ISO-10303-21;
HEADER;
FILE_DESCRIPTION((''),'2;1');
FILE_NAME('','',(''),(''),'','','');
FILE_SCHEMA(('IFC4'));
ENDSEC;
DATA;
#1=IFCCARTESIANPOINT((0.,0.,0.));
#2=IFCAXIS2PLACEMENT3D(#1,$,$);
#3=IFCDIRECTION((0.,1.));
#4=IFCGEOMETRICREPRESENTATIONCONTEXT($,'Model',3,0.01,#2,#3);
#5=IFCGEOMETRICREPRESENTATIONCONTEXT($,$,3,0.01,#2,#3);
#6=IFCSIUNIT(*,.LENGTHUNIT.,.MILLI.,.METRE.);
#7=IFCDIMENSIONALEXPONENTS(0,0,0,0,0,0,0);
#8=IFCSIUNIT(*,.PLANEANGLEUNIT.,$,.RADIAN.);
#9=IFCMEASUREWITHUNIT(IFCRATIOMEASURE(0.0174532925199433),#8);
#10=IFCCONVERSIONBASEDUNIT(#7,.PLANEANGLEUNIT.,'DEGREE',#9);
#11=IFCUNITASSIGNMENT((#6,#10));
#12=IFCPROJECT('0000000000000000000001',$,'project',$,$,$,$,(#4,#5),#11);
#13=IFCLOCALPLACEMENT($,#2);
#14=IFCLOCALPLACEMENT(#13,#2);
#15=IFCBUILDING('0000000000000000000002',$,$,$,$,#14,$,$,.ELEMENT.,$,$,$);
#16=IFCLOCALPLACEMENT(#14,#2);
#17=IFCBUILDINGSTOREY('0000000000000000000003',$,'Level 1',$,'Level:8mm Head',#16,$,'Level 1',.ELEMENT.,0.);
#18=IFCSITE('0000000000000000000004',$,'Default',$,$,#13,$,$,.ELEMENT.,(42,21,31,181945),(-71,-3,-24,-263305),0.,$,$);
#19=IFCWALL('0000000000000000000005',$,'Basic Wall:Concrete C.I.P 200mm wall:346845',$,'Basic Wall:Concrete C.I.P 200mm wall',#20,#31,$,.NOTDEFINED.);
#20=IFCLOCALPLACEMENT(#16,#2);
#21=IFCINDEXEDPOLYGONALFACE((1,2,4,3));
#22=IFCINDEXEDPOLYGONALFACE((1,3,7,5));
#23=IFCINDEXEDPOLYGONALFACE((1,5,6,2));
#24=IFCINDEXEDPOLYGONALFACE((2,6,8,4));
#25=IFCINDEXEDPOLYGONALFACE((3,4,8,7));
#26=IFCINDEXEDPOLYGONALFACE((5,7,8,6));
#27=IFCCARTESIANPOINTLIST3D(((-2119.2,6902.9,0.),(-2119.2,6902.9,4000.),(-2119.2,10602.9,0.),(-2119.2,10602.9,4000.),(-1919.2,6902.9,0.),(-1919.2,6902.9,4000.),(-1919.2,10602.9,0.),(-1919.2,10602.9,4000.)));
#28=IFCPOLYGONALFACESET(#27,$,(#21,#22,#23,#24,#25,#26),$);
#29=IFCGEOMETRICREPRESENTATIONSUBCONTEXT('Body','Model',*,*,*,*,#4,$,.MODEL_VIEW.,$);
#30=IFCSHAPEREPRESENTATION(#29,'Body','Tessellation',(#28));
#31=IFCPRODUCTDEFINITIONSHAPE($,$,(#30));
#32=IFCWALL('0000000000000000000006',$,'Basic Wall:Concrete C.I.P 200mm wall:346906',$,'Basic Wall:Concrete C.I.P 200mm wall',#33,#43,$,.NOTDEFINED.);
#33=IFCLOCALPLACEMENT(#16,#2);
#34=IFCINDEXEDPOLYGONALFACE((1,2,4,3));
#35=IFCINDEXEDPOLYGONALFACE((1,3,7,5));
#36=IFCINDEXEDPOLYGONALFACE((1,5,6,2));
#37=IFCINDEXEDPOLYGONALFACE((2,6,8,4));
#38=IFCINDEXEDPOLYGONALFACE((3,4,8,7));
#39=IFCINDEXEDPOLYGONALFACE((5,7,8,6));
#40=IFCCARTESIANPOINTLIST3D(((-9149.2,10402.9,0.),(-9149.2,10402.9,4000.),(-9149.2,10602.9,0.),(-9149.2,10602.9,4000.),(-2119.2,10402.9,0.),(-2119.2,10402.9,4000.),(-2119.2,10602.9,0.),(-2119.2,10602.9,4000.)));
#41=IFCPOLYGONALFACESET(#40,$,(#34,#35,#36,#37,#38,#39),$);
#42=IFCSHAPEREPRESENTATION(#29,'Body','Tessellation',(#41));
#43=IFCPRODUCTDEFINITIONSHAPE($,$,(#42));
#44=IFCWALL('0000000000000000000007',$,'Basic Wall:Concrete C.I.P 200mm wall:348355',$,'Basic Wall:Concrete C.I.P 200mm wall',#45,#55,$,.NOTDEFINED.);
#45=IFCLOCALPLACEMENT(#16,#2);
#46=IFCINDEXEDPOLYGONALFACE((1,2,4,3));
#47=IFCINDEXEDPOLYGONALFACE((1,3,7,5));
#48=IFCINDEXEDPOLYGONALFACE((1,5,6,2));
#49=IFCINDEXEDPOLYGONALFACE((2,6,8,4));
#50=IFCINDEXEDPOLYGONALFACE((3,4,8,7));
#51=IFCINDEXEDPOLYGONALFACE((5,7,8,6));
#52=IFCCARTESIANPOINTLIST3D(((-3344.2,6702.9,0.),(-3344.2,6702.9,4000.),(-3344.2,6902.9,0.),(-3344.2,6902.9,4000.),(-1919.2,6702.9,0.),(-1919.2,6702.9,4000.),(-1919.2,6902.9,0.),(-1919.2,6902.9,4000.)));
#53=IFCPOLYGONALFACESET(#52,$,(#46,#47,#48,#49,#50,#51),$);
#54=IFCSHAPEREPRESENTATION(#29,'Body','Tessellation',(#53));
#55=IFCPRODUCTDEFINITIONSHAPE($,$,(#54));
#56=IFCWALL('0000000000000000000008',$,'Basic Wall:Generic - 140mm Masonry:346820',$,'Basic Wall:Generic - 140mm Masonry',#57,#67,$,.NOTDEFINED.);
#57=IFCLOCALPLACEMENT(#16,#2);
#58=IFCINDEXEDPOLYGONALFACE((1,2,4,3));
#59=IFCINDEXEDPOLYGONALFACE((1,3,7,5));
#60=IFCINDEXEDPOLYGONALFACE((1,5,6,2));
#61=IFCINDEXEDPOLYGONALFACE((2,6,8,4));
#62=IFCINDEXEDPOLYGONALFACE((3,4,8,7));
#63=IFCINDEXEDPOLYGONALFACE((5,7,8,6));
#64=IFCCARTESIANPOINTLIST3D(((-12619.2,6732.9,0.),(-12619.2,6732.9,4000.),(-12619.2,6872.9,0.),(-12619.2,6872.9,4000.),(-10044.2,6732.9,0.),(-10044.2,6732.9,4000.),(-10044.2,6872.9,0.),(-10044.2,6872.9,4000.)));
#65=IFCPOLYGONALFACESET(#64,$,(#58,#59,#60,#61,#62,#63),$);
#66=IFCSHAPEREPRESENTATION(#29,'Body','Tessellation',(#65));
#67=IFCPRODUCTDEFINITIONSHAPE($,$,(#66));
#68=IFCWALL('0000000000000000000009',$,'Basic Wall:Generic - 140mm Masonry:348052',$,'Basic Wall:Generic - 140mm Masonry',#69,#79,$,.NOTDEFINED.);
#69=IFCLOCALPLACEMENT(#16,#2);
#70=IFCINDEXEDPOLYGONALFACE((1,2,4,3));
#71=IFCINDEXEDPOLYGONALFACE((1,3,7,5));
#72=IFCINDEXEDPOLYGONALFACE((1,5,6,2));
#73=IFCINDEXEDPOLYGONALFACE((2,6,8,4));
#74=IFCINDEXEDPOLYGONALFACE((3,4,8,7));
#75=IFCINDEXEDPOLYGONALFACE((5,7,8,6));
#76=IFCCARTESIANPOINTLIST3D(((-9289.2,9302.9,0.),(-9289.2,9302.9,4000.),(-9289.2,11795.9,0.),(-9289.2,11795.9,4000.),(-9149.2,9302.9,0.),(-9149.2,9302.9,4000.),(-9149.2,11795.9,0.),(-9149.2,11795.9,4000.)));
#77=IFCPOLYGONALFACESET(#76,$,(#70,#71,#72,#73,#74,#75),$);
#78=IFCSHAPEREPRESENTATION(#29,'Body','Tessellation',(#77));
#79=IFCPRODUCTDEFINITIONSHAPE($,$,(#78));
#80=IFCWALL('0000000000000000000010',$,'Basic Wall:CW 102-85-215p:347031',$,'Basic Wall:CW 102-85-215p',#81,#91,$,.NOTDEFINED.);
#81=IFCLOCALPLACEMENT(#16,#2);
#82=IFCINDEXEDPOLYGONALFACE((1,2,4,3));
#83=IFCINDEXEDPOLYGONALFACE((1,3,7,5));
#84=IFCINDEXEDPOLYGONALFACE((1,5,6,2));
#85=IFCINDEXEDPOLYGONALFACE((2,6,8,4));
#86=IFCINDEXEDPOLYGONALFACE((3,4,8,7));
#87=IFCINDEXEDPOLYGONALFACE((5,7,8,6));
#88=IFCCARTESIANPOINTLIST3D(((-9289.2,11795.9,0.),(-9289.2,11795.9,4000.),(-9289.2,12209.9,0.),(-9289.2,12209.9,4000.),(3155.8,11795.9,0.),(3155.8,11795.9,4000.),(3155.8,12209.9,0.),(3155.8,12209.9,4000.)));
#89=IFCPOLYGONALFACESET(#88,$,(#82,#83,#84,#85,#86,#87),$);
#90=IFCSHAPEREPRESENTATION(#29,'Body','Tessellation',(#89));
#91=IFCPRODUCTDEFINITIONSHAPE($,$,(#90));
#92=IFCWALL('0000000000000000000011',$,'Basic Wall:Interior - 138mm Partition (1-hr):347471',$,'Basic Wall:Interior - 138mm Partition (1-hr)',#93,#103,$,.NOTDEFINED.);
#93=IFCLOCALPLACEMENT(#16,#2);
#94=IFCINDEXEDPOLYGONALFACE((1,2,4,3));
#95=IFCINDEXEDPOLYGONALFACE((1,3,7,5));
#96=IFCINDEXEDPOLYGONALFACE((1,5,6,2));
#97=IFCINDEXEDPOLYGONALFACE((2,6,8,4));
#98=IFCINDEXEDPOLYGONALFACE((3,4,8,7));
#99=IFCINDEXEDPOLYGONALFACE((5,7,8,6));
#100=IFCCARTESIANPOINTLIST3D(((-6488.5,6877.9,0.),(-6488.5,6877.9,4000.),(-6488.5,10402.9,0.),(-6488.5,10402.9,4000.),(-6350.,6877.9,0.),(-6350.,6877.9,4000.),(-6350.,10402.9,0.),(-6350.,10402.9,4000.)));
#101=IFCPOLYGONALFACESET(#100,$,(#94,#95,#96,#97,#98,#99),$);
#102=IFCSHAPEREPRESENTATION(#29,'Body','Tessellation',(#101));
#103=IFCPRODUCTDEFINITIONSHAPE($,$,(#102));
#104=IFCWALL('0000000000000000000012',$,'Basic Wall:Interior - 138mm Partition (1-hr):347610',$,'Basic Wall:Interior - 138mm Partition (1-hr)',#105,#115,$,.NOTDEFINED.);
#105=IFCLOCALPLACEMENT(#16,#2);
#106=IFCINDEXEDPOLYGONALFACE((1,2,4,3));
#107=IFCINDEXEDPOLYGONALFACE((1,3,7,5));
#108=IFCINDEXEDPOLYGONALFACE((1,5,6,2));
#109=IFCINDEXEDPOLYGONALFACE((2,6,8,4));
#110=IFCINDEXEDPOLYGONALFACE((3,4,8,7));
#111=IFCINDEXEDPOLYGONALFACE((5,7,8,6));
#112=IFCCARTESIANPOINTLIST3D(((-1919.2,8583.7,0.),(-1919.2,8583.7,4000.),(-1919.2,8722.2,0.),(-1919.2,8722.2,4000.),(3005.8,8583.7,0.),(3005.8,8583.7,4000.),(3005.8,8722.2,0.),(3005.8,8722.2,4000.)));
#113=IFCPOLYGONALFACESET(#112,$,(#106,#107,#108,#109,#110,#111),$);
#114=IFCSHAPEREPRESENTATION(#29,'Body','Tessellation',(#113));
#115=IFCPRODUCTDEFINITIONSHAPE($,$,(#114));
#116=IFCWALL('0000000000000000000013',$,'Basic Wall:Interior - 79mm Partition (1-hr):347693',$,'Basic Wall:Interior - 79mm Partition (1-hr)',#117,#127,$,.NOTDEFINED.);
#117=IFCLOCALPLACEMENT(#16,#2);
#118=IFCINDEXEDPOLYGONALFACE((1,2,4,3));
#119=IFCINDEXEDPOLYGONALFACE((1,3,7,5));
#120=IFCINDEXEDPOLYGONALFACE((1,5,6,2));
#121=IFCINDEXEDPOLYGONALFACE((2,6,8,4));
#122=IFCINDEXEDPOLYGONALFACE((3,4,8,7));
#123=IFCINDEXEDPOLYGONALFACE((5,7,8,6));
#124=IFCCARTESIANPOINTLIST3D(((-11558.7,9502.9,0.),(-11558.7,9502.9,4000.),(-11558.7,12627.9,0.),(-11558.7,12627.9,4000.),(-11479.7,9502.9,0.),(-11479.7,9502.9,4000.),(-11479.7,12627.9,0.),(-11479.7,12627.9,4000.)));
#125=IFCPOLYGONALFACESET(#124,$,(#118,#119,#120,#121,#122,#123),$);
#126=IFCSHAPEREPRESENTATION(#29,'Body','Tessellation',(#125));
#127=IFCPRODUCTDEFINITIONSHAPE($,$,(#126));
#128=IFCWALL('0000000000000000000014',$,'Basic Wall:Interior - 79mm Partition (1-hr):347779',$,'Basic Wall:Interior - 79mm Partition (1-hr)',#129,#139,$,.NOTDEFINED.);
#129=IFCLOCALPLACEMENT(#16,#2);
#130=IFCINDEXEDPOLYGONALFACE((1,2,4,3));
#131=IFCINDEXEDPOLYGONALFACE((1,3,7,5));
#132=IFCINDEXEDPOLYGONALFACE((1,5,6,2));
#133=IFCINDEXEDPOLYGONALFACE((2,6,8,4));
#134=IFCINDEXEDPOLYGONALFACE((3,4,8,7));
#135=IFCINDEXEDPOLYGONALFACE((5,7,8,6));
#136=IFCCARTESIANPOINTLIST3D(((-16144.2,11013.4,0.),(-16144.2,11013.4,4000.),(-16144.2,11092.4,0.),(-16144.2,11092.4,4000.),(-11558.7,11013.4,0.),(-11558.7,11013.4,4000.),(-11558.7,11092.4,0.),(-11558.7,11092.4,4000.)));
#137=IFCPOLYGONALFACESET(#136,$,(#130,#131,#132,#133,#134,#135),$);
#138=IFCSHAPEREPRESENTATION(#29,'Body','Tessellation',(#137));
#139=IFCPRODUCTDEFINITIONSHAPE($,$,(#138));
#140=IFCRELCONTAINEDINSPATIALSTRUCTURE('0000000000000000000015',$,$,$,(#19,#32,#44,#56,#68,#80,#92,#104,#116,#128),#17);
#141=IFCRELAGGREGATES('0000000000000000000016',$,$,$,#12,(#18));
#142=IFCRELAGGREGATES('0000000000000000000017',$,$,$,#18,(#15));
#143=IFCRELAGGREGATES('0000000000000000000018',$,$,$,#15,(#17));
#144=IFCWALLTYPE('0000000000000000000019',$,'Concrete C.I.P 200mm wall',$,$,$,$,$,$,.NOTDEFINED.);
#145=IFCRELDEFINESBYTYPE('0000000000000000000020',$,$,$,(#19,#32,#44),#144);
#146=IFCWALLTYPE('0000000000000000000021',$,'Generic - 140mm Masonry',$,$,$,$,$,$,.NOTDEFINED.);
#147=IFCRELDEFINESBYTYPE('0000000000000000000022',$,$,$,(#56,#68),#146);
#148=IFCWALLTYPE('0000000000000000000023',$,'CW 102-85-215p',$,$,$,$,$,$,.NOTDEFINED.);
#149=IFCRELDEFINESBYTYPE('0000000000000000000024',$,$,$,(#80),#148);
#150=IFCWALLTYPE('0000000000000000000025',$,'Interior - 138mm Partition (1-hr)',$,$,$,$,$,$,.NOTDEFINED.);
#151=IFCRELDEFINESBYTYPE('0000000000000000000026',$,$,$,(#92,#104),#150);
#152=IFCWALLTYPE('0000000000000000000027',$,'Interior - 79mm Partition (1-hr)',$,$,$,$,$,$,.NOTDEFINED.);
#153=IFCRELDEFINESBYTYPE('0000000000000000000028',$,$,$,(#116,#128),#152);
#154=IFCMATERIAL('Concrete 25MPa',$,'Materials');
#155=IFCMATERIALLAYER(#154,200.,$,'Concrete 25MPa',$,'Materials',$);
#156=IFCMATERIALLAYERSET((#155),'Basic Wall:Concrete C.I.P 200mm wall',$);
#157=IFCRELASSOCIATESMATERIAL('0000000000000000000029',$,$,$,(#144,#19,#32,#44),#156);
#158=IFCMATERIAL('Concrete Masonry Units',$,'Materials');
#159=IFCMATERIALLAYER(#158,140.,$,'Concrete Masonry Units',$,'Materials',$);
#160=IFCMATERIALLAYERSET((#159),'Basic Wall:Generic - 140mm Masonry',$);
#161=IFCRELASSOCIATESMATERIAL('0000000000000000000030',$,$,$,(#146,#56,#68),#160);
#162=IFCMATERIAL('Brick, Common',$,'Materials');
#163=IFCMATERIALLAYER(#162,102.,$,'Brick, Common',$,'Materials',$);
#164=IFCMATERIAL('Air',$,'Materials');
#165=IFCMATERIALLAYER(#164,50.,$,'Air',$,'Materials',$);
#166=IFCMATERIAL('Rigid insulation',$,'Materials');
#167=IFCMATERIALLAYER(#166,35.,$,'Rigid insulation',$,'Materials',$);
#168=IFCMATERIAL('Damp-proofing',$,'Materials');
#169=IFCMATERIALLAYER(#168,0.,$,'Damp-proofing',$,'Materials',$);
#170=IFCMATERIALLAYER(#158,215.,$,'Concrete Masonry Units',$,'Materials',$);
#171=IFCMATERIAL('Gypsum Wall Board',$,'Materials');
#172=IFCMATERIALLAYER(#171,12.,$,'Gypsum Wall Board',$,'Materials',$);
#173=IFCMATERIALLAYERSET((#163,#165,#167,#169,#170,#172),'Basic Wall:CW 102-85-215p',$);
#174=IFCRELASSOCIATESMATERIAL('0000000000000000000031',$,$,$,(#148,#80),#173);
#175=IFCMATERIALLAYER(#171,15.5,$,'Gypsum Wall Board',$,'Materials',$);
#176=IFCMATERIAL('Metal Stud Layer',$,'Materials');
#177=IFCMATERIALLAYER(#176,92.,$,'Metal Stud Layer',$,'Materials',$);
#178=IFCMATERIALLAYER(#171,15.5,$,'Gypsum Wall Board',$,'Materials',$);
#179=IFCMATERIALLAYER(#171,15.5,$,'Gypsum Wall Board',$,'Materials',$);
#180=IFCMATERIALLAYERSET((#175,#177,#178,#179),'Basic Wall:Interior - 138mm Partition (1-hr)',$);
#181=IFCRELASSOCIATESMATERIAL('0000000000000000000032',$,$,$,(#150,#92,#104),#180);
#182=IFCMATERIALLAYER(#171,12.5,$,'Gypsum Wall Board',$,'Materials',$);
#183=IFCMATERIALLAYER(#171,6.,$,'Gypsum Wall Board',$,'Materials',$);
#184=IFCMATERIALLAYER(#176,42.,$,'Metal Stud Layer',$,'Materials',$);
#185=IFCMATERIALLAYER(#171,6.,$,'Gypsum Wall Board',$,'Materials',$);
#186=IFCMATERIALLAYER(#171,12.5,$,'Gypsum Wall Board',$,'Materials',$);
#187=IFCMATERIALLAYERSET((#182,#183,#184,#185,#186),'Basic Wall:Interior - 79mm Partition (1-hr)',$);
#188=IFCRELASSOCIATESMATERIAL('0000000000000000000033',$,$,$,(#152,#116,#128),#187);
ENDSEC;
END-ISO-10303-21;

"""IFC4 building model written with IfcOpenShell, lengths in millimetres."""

from ifc_helpers import new_model, entity, si_unit, converted_unit, direction, frame, frame_2d, origin, place, context, subcontext, project, spatial, rectangle, extrude, material, layer, layer_set, layer_usage, type_object, element, save


model = new_model("IFC4")

# Units and contexts
model_context = context("Model", 3, precision=0.01, world=origin(), true_north=direction((0.0, 1.0)))
context_of_model = context(None, 3, precision=0.01, world=origin(), true_north=direction((0.0, 1.0)))
body_context = subcontext(model_context, "Body", "Model", "MODEL_VIEW")
ifc_project = project(units=[si_unit("LENGTHUNIT", "METRE", prefix="MILLI"), converted_unit("PLANEANGLEUNIT", "DEGREE", entity("IfcRatioMeasure", 0.0174532925199433), si_unit("PLANEANGLEUNIT", "RADIAN"), dimensions=[0, 0, 0, 0, 0, 0, 0])], contexts=[model_context, context_of_model])

# Site, building, storey
site_placement = place(None, origin())
site = spatial("IfcSite", under=ifc_project, at=site_placement, Name="Default", CompositionType="ELEMENT", RefLatitude=(42, 21, 31, 181945), RefLongitude=(-71, -3, -24, -263305), RefElevation=0.0)
building_placement = place(site_placement, origin())
building = spatial("IfcBuilding", under=site, at=building_placement, CompositionType="ELEMENT")
storey_placement = place(building_placement, origin())
storey = spatial("IfcBuildingStorey", under=building, at=storey_placement, Name="Level 1", ObjectType="Level:8mm Head", LongName="Level 1", CompositionType="ELEMENT", Elevation=0.0)

# Walls
ifc_material_1 = material(Name="Concrete 25MPa", Category="Materials")
ifc_layer_1 = layer(ifc_material_1, 200.0, Name="Concrete 25MPa", Category="Materials")
ifc_layer_set_1 = layer_set([ifc_layer_1], Name="Basic Wall:Concrete C.I.P 200mm wall")
wall_type_1 = type_object("IfcWallType", Name="Concrete C.I.P 200mm wall", PredefinedType="NOTDEFINED", material=ifc_layer_set_1)
ifc_layer_usage_1 = layer_usage(ifc_layer_set_1, "AXIS2", "NEGATIVE", 100.0)
wall_1_placement = place(storey_placement, frame((-2019.2, 6902.9, 0.0), z_axis=(0.0, 0.0, 1.0), x_axis=(0.0, 1.0, 0.0)))
element("IfcWall", 1, at=wall_1_placement, inside=storey, type_object=wall_type_1, material=ifc_layer_usage_1, Name="Basic Wall:Concrete C.I.P 200mm wall:346845", ObjectType="Basic Wall:Concrete C.I.P 200mm wall", PredefinedType="NOTDEFINED", context=body_context, shape_type="SweptSolid", body=[
    extrude(rectangle(XDim=3700.0, YDim=200.0, at=frame_2d((1850.0, 0.0), x_axis=(-1.0, 0.0))), origin(), (0.0, 0.0, 1.0), 4000.0),
])
ifc_layer_usage_2 = layer_usage(ifc_layer_set_1, "AXIS2", "NEGATIVE", 100.0)
wall_2_placement = place(storey_placement, frame((-2119.2, 10502.9, 0.0), z_axis=(0.0, 0.0, 1.0), x_axis=(-1.0, 0.0, 0.0)))
element("IfcWall", 2, at=wall_2_placement, inside=storey, type_object=wall_type_1, material=ifc_layer_usage_2, Name="Basic Wall:Concrete C.I.P 200mm wall:346906", ObjectType="Basic Wall:Concrete C.I.P 200mm wall", PredefinedType="NOTDEFINED", context=body_context, shape_type="SweptSolid", body=[
    extrude(rectangle(XDim=7030.0, YDim=200.0, at=frame_2d((3515.0, 0.0), x_axis=(-1.0, 0.0))), origin(), (0.0, 0.0, 1.0), 4000.0),
])
ifc_layer_usage_3 = layer_usage(ifc_layer_set_1, "AXIS2", "NEGATIVE", 100.0)
wall_3_placement = place(storey_placement, frame((-3344.2, 6802.9, 0.0)))
element("IfcWall", 3, at=wall_3_placement, inside=storey, type_object=wall_type_1, material=ifc_layer_usage_3, Name="Basic Wall:Concrete C.I.P 200mm wall:348355", ObjectType="Basic Wall:Concrete C.I.P 200mm wall", PredefinedType="NOTDEFINED", context=body_context, shape_type="SweptSolid", body=[
    extrude(rectangle(XDim=1425.0, YDim=200.0, at=frame_2d((712.5, 0.0), x_axis=(-1.0, 0.0))), origin(), (0.0, 0.0, 1.0), 4000.0),
])
ifc_material_2 = material(Name="Concrete Masonry Units", Category="Materials")
ifc_layer_2 = layer(ifc_material_2, 140.0, Name="Concrete Masonry Units", Category="Materials")
ifc_layer_set_2 = layer_set([ifc_layer_2], Name="Basic Wall:Generic - 140mm Masonry")
ifc_layer_usage_4 = layer_usage(ifc_layer_set_2, "AXIS2", "NEGATIVE", 70.0)
wall_type_2 = type_object("IfcWallType", Name="Generic - 140mm Masonry", PredefinedType="NOTDEFINED", material=ifc_layer_set_2)
wall_4_placement = place(storey_placement, frame((-12619.2, 6802.9, 0.0)))
element("IfcWall", 4, at=wall_4_placement, inside=storey, type_object=wall_type_2, material=ifc_layer_usage_4, Name="Basic Wall:Generic - 140mm Masonry:346820", ObjectType="Basic Wall:Generic - 140mm Masonry", PredefinedType="NOTDEFINED", context=body_context, shape_type="SweptSolid", body=[
    extrude(rectangle(XDim=2575.0, YDim=140.0, at=frame_2d((1287.5, 0.0), x_axis=(-1.0, 0.0))), origin(), (0.0, 0.0, 1.0), 4000.0),
])
ifc_layer_usage_5 = layer_usage(ifc_layer_set_2, "AXIS2", "NEGATIVE", 70.0)
wall_5_placement = place(storey_placement, frame((-9219.2, 11795.9, 0.0), z_axis=(0.0, 0.0, 1.0), x_axis=(0.0, -1.0, 0.0)))
element("IfcWall", 5, at=wall_5_placement, inside=storey, type_object=wall_type_2, material=ifc_layer_usage_5, Name="Basic Wall:Generic - 140mm Masonry:348052", ObjectType="Basic Wall:Generic - 140mm Masonry", PredefinedType="NOTDEFINED", context=body_context, shape_type="SweptSolid", body=[
    extrude(rectangle(XDim=2493.0, YDim=140.0, at=frame_2d((1246.5, 0.0), x_axis=(-1.0, 0.0))), origin(), (0.0, 0.0, 1.0), 4000.0),
])
ifc_material_3 = material(Name="Brick, Common", Category="Materials")
ifc_layer_3 = layer(ifc_material_3, 102.0, Name="Brick, Common", Category="Materials")
ifc_material_4 = material(Name="Air", Category="Materials")
ifc_layer_4 = layer(ifc_material_4, 50.0, Name="Air", Category="Materials")
ifc_material_5 = material(Name="Rigid insulation", Category="Materials")
ifc_layer_5 = layer(ifc_material_5, 35.0, Name="Rigid insulation", Category="Materials")
ifc_material_6 = material(Name="Damp-proofing", Category="Materials")
ifc_layer_6 = layer(ifc_material_6, 0.0, Name="Damp-proofing", Category="Materials")
ifc_layer_7 = layer(ifc_material_2, 215.0, Name="Concrete Masonry Units", Category="Materials")
ifc_material_7 = material(Name="Gypsum Wall Board", Category="Materials")
ifc_layer_8 = layer(ifc_material_7, 12.0, Name="Gypsum Wall Board", Category="Materials")
ifc_layer_set_3 = layer_set([ifc_layer_3, ifc_layer_4, ifc_layer_5, ifc_layer_6, ifc_layer_7, ifc_layer_8], Name="Basic Wall:CW 102-85-215p")
ifc_layer_usage_6 = layer_usage(ifc_layer_set_3, "AXIS2", "NEGATIVE", 207.0)
wall_type_3 = type_object("IfcWallType", Name="CW 102-85-215p", PredefinedType="NOTDEFINED", material=ifc_layer_set_3)
wall_6_placement = place(storey_placement, frame((-9289.2, 12002.9, 0.0)))
element("IfcWall", 6, at=wall_6_placement, inside=storey, type_object=wall_type_3, material=ifc_layer_usage_6, Name="Basic Wall:CW 102-85-215p:347031", ObjectType="Basic Wall:CW 102-85-215p", PredefinedType="NOTDEFINED", context=body_context, shape_type="SweptSolid", body=[
    extrude(rectangle(XDim=12445.0, YDim=414.0, at=frame_2d((6222.5, 0.0), x_axis=(-1.0, 0.0))), origin(), (0.0, 0.0, 1.0), 4000.0),
])
ifc_layer_9 = layer(ifc_material_7, 15.5, Name="Gypsum Wall Board", Category="Materials")
ifc_material_8 = material(Name="Metal Stud Layer", Category="Materials")
ifc_layer_10 = layer(ifc_material_8, 92.0, Name="Metal Stud Layer", Category="Materials")
ifc_layer_11 = layer(ifc_material_7, 15.5, Name="Gypsum Wall Board", Category="Materials")
ifc_layer_12 = layer(ifc_material_7, 15.5, Name="Gypsum Wall Board", Category="Materials")
ifc_layer_set_4 = layer_set([ifc_layer_9, ifc_layer_10, ifc_layer_11, ifc_layer_12], Name="Basic Wall:Interior - 138mm Partition (1-hr)")
ifc_layer_usage_7 = layer_usage(ifc_layer_set_4, "AXIS2", "NEGATIVE", 69.2)
wall_type_4 = type_object("IfcWallType", Name="Interior - 138mm Partition (1-hr)", PredefinedType="NOTDEFINED", material=ifc_layer_set_4)
wall_7_placement = place(storey_placement, frame((-6419.2, 10402.9, 0.0), z_axis=(0.0, 0.0, 1.0), x_axis=(0.0, -1.0, 0.0)))
element("IfcWall", 7, at=wall_7_placement, inside=storey, type_object=wall_type_4, material=ifc_layer_usage_7, Name="Basic Wall:Interior - 138mm Partition (1-hr):347471", ObjectType="Basic Wall:Interior - 138mm Partition (1-hr)", PredefinedType="NOTDEFINED", context=body_context, shape_type="SweptSolid", body=[
    extrude(rectangle(XDim=3525.0, YDim=138.5, at=frame_2d((1762.5, 0.0), x_axis=(-1.0, 0.0))), origin(), (0.0, 0.0, 1.0), 4000.0),
])
ifc_layer_usage_8 = layer_usage(ifc_layer_set_4, "AXIS2", "NEGATIVE", 69.2)
wall_8_placement = place(storey_placement, frame((-1919.2, 8652.9, 0.0)))
element("IfcWall", 8, at=wall_8_placement, inside=storey, type_object=wall_type_4, material=ifc_layer_usage_8, Name="Basic Wall:Interior - 138mm Partition (1-hr):347610", ObjectType="Basic Wall:Interior - 138mm Partition (1-hr)", PredefinedType="NOTDEFINED", context=body_context, shape_type="SweptSolid", body=[
    extrude(rectangle(XDim=4925.0, YDim=138.5, at=frame_2d((2462.5, 0.0), x_axis=(-1.0, 0.0))), origin(), (0.0, 0.0, 1.0), 4000.0),
])
ifc_layer_13 = layer(ifc_material_7, 12.5, Name="Gypsum Wall Board", Category="Materials")
ifc_layer_14 = layer(ifc_material_7, 6.0, Name="Gypsum Wall Board", Category="Materials")
ifc_layer_15 = layer(ifc_material_8, 42.0, Name="Metal Stud Layer", Category="Materials")
ifc_layer_16 = layer(ifc_material_7, 6.0, Name="Gypsum Wall Board", Category="Materials")
ifc_layer_17 = layer(ifc_material_7, 12.5, Name="Gypsum Wall Board", Category="Materials")
ifc_layer_set_5 = layer_set([ifc_layer_13, ifc_layer_14, ifc_layer_15, ifc_layer_16, ifc_layer_17], Name="Basic Wall:Interior - 79mm Partition (1-hr)")
ifc_layer_usage_9 = layer_usage(ifc_layer_set_5, "AXIS2", "NEGATIVE", 39.5)
wall_type_5 = type_object("IfcWallType", Name="Interior - 79mm Partition (1-hr)", PredefinedType="NOTDEFINED", material=ifc_layer_set_5)
wall_9_placement = place(storey_placement, frame((-11519.2, 9502.9, 0.0), z_axis=(0.0, 0.0, 1.0), x_axis=(0.0, 1.0, 0.0)))
element("IfcWall", 9, at=wall_9_placement, inside=storey, type_object=wall_type_5, material=ifc_layer_usage_9, Name="Basic Wall:Interior - 79mm Partition (1-hr):347693", ObjectType="Basic Wall:Interior - 79mm Partition (1-hr)", PredefinedType="NOTDEFINED", context=body_context, shape_type="SweptSolid", body=[
    extrude(rectangle(XDim=3125.0, YDim=79.0, at=frame_2d((1562.5, 0.0), x_axis=(-1.0, 0.0))), origin(), (0.0, 0.0, 1.0), 4000.0),
])
ifc_layer_usage_10 = layer_usage(ifc_layer_set_5, "AXIS2", "NEGATIVE", 39.5)
wall_10_placement = place(storey_placement, frame((-16144.2, 11052.9, 0.0)))
element("IfcWall", 10, at=wall_10_placement, inside=storey, type_object=wall_type_5, material=ifc_layer_usage_10, Name="Basic Wall:Interior - 79mm Partition (1-hr):347779", ObjectType="Basic Wall:Interior - 79mm Partition (1-hr)", PredefinedType="NOTDEFINED", context=body_context, shape_type="SweptSolid", body=[
    extrude(rectangle(XDim=4585.5, YDim=79.0, at=frame_2d((2292.8, 0.0), x_axis=(-1.0, 0.0))), origin(), (0.0, 0.0, 1.0), 4000.0),
])

save(model, "model.ifc")
